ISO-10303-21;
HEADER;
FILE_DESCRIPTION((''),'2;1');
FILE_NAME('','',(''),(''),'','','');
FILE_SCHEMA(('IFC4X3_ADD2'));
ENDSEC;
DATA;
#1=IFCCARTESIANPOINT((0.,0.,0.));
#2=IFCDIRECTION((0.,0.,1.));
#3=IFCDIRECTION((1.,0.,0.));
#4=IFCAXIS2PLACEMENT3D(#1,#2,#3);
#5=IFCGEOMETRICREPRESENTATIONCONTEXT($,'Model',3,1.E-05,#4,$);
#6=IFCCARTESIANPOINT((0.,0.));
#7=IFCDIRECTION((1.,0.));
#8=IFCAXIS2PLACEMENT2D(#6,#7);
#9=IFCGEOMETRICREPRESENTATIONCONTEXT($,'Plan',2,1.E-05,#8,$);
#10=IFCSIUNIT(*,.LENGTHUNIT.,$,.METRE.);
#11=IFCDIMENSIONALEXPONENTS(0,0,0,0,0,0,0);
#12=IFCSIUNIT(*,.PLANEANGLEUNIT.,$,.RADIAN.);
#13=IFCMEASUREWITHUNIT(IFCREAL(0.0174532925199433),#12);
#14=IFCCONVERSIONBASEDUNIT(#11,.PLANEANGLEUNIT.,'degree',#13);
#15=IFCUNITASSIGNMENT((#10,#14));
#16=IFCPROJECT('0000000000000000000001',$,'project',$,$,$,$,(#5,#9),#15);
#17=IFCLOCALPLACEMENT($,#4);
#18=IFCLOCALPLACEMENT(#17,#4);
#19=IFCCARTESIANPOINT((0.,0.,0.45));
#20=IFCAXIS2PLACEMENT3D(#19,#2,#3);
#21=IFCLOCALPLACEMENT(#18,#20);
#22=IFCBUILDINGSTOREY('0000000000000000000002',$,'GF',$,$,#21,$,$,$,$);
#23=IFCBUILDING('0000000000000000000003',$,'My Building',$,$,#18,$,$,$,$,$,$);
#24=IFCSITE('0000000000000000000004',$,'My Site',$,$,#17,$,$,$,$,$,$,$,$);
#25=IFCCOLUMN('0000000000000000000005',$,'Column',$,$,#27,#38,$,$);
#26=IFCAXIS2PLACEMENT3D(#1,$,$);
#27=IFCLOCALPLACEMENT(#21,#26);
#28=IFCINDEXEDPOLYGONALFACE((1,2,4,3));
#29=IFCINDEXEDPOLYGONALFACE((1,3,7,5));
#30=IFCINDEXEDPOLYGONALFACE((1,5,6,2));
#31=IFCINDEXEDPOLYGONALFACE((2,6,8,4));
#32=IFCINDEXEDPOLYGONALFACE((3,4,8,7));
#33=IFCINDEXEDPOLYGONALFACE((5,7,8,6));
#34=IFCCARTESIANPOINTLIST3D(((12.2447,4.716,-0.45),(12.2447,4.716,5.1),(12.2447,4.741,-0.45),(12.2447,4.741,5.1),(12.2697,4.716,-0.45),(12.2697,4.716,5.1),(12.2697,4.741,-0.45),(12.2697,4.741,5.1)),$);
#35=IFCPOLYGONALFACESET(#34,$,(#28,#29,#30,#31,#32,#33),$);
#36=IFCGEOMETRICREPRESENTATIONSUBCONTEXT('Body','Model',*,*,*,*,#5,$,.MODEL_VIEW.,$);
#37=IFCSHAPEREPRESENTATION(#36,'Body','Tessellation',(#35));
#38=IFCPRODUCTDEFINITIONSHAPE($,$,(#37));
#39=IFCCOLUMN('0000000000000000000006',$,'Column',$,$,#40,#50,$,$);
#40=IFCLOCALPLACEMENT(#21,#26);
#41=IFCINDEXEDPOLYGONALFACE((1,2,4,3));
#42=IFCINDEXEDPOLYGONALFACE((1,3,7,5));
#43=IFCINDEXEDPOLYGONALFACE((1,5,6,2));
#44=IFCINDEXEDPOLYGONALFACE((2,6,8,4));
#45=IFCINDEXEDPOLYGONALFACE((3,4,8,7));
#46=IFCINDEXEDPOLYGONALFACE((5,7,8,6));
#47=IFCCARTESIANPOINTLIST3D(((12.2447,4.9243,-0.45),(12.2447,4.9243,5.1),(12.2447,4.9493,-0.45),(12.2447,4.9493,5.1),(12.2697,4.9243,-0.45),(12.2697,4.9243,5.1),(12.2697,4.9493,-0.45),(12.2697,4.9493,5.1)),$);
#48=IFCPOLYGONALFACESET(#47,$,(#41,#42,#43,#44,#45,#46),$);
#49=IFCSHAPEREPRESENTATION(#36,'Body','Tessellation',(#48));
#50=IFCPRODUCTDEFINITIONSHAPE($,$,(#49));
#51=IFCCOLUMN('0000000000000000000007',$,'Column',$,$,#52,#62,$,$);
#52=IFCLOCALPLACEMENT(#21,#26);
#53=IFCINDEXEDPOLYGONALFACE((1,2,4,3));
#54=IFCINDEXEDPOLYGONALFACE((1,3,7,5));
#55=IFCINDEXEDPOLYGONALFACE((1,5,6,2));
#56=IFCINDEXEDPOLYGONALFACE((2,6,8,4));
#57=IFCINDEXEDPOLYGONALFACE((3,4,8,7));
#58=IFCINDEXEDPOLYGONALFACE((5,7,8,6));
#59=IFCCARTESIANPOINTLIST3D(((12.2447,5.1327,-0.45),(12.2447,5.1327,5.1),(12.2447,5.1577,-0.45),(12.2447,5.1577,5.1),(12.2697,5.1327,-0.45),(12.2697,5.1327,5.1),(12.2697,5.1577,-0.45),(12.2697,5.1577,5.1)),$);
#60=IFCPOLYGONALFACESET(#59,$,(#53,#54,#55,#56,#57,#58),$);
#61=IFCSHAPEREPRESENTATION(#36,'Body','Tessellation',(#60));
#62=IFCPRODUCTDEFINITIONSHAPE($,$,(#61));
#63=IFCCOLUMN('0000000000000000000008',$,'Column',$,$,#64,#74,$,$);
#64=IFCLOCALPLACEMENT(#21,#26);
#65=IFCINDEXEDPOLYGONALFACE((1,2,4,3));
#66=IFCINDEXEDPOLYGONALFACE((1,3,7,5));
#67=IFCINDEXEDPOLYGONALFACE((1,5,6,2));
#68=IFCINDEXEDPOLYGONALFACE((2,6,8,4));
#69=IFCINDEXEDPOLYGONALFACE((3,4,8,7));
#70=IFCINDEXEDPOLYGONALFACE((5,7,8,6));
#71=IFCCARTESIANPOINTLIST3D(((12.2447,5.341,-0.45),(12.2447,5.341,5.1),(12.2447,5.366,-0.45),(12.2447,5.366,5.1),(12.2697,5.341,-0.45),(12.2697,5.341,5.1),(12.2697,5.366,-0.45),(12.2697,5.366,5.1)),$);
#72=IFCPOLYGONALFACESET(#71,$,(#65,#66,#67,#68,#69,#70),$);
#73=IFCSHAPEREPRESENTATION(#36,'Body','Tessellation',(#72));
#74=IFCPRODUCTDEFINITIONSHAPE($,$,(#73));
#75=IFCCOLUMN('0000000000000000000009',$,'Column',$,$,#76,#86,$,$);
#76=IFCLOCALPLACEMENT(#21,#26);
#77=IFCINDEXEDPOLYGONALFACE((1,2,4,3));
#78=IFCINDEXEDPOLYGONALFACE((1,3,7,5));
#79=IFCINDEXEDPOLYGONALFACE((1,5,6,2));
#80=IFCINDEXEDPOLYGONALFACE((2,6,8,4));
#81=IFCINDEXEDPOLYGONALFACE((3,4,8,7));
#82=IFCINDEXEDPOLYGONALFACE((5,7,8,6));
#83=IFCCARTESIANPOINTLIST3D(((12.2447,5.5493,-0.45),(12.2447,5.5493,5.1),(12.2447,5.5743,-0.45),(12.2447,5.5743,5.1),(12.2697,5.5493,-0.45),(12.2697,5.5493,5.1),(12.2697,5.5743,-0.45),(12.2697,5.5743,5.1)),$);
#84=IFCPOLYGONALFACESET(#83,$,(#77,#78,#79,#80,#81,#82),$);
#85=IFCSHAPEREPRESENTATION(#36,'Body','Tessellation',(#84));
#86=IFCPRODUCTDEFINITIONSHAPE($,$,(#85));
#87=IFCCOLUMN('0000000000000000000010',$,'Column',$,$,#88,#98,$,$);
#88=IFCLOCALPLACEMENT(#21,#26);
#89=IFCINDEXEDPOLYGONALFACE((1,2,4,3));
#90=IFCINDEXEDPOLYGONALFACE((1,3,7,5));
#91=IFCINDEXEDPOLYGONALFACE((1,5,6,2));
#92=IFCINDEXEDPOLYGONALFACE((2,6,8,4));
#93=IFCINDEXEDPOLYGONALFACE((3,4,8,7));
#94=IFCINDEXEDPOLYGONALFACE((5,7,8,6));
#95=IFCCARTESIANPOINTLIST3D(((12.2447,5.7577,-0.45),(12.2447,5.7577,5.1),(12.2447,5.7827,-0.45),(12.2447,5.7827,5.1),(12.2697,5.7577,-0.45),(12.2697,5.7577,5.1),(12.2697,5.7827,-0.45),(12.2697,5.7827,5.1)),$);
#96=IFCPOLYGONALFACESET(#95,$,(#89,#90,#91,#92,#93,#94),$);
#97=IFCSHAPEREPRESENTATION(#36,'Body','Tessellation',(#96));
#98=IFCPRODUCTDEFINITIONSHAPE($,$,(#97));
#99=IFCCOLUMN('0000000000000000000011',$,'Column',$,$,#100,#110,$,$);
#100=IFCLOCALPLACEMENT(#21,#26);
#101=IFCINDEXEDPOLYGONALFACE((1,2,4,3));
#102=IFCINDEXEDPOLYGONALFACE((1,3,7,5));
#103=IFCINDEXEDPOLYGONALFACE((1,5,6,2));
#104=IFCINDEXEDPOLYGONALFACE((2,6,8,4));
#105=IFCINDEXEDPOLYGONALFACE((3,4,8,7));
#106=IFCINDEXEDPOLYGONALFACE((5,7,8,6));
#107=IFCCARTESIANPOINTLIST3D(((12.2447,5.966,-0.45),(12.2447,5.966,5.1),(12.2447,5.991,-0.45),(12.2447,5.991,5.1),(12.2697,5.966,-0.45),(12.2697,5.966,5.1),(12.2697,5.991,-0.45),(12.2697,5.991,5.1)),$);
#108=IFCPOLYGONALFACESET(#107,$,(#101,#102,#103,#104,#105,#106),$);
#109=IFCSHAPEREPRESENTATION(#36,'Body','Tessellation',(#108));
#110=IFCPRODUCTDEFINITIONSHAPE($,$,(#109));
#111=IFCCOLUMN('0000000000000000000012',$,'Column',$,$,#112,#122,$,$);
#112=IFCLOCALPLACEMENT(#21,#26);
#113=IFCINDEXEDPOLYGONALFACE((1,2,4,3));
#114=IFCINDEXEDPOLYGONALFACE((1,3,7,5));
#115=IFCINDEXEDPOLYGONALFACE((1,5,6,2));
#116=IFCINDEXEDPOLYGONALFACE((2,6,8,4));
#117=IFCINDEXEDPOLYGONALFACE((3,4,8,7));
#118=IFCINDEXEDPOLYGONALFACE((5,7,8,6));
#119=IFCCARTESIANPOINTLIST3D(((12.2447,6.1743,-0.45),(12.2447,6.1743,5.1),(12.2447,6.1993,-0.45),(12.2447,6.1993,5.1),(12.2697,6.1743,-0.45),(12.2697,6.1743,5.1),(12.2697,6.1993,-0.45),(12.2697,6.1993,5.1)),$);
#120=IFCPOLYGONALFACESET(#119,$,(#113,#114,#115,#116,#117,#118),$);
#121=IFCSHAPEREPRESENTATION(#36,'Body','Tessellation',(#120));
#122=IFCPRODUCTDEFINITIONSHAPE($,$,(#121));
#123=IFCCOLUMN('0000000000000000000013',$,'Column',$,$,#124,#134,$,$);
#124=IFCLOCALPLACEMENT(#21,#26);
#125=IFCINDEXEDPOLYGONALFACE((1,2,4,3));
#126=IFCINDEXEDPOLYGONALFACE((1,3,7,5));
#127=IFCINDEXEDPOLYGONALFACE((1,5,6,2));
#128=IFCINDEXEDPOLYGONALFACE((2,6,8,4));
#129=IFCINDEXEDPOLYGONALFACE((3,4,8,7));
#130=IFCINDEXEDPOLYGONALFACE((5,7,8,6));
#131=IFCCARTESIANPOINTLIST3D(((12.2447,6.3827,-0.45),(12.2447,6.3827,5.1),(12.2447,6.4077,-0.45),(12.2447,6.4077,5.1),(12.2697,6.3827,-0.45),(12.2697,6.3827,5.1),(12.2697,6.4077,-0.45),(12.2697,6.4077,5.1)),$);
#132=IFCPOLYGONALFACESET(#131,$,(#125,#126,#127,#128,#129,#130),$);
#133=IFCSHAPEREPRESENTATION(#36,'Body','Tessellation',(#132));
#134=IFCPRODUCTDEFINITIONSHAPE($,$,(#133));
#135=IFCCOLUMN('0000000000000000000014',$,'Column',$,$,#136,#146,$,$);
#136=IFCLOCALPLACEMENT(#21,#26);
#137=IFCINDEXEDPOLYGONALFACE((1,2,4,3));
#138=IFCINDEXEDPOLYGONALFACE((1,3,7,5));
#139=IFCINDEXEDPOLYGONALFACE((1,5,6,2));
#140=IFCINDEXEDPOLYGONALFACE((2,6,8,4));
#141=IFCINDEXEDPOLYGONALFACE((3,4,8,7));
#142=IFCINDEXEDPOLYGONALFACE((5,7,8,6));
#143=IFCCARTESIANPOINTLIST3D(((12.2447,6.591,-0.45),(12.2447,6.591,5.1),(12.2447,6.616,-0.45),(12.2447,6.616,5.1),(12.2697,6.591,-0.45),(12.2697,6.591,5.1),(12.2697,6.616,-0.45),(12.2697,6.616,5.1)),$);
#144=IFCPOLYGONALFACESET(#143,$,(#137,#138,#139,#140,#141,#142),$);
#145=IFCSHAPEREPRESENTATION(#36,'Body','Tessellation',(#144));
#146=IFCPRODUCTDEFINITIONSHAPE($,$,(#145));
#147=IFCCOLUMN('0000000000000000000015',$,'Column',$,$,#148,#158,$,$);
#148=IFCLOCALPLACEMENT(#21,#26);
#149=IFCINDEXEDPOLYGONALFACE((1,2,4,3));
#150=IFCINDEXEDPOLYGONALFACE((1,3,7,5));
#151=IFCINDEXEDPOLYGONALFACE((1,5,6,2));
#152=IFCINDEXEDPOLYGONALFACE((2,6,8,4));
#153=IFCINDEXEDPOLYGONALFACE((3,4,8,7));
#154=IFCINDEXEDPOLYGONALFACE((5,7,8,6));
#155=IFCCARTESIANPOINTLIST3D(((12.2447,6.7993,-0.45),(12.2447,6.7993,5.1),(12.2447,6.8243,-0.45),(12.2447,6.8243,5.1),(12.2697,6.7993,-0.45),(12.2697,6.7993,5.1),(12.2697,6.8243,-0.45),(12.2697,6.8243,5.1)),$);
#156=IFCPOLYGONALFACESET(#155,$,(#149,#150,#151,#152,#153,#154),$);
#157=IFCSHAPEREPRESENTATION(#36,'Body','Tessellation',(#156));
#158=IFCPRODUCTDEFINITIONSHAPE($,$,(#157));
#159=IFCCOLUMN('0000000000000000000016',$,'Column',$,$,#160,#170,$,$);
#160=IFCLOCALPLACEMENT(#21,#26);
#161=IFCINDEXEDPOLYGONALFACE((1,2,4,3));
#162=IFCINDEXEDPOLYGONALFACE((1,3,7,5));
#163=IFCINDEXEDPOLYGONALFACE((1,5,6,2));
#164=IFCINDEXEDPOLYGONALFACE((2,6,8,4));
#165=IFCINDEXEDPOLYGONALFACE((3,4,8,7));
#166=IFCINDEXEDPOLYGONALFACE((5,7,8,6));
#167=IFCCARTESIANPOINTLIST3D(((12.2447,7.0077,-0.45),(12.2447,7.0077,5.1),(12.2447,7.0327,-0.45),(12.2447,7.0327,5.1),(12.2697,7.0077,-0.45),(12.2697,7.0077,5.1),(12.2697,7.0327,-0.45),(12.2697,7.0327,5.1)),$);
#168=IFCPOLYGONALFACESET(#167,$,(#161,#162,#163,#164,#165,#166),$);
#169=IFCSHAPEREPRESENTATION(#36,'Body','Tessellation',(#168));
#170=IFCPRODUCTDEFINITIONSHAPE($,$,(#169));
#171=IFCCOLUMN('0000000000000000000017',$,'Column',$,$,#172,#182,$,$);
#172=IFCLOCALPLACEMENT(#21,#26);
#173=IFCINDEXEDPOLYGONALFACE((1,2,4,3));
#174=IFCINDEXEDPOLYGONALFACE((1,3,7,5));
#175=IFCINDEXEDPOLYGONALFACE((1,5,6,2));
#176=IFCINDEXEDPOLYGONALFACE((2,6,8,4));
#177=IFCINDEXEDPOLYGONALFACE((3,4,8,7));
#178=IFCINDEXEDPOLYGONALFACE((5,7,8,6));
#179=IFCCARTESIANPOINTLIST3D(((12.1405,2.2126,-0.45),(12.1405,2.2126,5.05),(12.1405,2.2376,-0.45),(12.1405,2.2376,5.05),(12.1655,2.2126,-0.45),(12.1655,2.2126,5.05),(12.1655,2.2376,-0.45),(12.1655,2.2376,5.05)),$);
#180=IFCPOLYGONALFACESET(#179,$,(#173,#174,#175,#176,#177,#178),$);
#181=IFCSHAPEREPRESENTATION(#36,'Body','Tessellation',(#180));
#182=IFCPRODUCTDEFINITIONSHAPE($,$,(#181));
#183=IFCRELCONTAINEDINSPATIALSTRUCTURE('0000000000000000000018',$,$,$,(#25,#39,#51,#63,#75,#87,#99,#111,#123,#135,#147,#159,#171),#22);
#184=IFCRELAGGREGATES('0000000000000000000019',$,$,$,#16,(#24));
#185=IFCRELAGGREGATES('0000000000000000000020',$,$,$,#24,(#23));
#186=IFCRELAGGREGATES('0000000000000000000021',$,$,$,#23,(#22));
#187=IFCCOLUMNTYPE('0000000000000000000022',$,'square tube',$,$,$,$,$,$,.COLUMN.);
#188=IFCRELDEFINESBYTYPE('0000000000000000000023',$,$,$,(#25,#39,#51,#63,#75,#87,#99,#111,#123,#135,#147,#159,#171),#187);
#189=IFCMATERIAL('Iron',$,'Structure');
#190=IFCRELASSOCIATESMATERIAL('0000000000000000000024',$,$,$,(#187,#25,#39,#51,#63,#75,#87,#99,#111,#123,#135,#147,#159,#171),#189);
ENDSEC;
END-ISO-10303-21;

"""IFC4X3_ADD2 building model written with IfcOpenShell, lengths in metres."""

from ifc_helpers import new_model, entity, si_unit, converted_unit, frame, origin_with_axes, origin_2d_with_axis, place, context, subcontext, project, spatial, indexed_curve, outline, extrude, material, material_profile, profile_set, profile_usage, type_object, element, save


model = new_model("IFC4X3_ADD2")

# Units and contexts
model_context = context("Model", 3, precision=1e-05, world=origin_with_axes())
plan_context = context("Plan", 2, precision=1e-05, world=origin_2d_with_axis())
body_context = subcontext(model_context, "Body", "Model", "MODEL_VIEW")
ifc_project = project(units=[si_unit("LENGTHUNIT", "METRE"), converted_unit("PLANEANGLEUNIT", "degree", entity("IfcReal", 0.0174532925199433), si_unit("PLANEANGLEUNIT", "RADIAN"), dimensions=[0, 0, 0, 0, 0, 0, 0])], contexts=[model_context, plan_context])

# Site, building, storey
site_placement = place(None, origin_with_axes())
site = spatial("IfcSite", under=ifc_project, at=site_placement, Name="My Site")
building_placement = place(site_placement, origin_with_axes())
building = spatial("IfcBuilding", under=site, at=building_placement, Name="My Building")
storey_placement = place(building_placement, frame((0.0, 0.0, 0.45), z_axis=(0.0, 0.0, 1.0), x_axis=(1.0, 0.0, 0.0)))
storey = spatial("IfcBuildingStorey", under=building, at=storey_placement, Name="GF")

# Columns
ifc_material_1 = material(Name="Iron", Category="Structure")
ifc_material_profile = material_profile(ifc_material_1, outline(indexed_curve([(-0.0125, -0.0125), (0.0125, -0.0125), (0.0125, 0.0125), (-0.0125, 0.0125), (-0.0125, -0.0125)])))
ifc_profile_set = profile_set([ifc_material_profile])
column_type = type_object("IfcColumnType", Name="square tube", PredefinedType="COLUMN", material=ifc_profile_set)
ifc_profile_usage_1 = profile_usage(ifc_profile_set, cardinal=5)
column_1_placement = place(storey_placement, frame((12.2572, 4.7285, -0.45), z_axis=(0.0, 0.0, 1.0), x_axis=(0.0, 1.0, 0.0)))
element("IfcColumn", 1, at=column_1_placement, inside=storey, type_object=column_type, material=ifc_profile_usage_1, Name="Column", context=body_context, shape_type="SweptSolid", body=[
    extrude(outline(indexed_curve([(-0.0125, -0.0125), (0.0125, -0.0125), (0.0125, 0.0125), (-0.0125, 0.0125), (-0.0125, -0.0125)])), origin_with_axes(), (0.0, 0.0, 1.0), 5.55),
])
ifc_profile_usage_2 = profile_usage(ifc_profile_set, cardinal=5)
column_2_placement = place(storey_placement, frame((12.2572, 4.9368, -0.45), z_axis=(0.0, 0.0, 1.0), x_axis=(0.0, 1.0, 0.0)))
element("IfcColumn", 2, at=column_2_placement, inside=storey, type_object=column_type, material=ifc_profile_usage_2, Name="Column", context=body_context, shape_type="SweptSolid", body=[
    extrude(outline(indexed_curve([(-0.0125, -0.0125), (0.0125, -0.0125), (0.0125, 0.0125), (-0.0125, 0.0125), (-0.0125, -0.0125)])), origin_with_axes(), (0.0, 0.0, 1.0), 5.55),
])
ifc_profile_usage_3 = profile_usage(ifc_profile_set, cardinal=5)
column_3_placement = place(storey_placement, frame((12.2572, 5.1452, -0.45), z_axis=(0.0, 0.0, 1.0), x_axis=(0.0, 1.0, 0.0)))
element("IfcColumn", 3, at=column_3_placement, inside=storey, type_object=column_type, material=ifc_profile_usage_3, Name="Column", context=body_context, shape_type="SweptSolid", body=[
    extrude(outline(indexed_curve([(-0.0125, -0.0125), (0.0125, -0.0125), (0.0125, 0.0125), (-0.0125, 0.0125), (-0.0125, -0.0125)])), origin_with_axes(), (0.0, 0.0, 1.0), 5.55),
])
ifc_profile_usage_4 = profile_usage(ifc_profile_set, cardinal=5)
column_4_placement = place(storey_placement, frame((12.2572, 5.3535, -0.45), z_axis=(0.0, 0.0, 1.0), x_axis=(0.0, 1.0, 0.0)))
element("IfcColumn", 4, at=column_4_placement, inside=storey, type_object=column_type, material=ifc_profile_usage_4, Name="Column", context=body_context, shape_type="SweptSolid", body=[
    extrude(outline(indexed_curve([(-0.0125, -0.0125), (0.0125, -0.0125), (0.0125, 0.0125), (-0.0125, 0.0125), (-0.0125, -0.0125)])), origin_with_axes(), (0.0, 0.0, 1.0), 5.55),
])
ifc_profile_usage_5 = profile_usage(ifc_profile_set, cardinal=5)
column_5_placement = place(storey_placement, frame((12.2572, 5.5618, -0.45), z_axis=(0.0, 0.0, 1.0), x_axis=(0.0, 1.0, 0.0)))
element("IfcColumn", 5, at=column_5_placement, inside=storey, type_object=column_type, material=ifc_profile_usage_5, Name="Column", context=body_context, shape_type="SweptSolid", body=[
    extrude(outline(indexed_curve([(-0.0125, -0.0125), (0.0125, -0.0125), (0.0125, 0.0125), (-0.0125, 0.0125), (-0.0125, -0.0125)])), origin_with_axes(), (0.0, 0.0, 1.0), 5.55),
])
ifc_profile_usage_6 = profile_usage(ifc_profile_set, cardinal=5)
column_6_placement = place(storey_placement, frame((12.2572, 5.7702, -0.45), z_axis=(0.0, 0.0, 1.0), x_axis=(0.0, 1.0, 0.0)))
element("IfcColumn", 6, at=column_6_placement, inside=storey, type_object=column_type, material=ifc_profile_usage_6, Name="Column", context=body_context, shape_type="SweptSolid", body=[
    extrude(outline(indexed_curve([(-0.0125, -0.0125), (0.0125, -0.0125), (0.0125, 0.0125), (-0.0125, 0.0125), (-0.0125, -0.0125)])), origin_with_axes(), (0.0, 0.0, 1.0), 5.55),
])
ifc_profile_usage_7 = profile_usage(ifc_profile_set, cardinal=5)
column_7_placement = place(storey_placement, frame((12.2572, 5.9785, -0.45), z_axis=(0.0, 0.0, 1.0), x_axis=(0.0, 1.0, 0.0)))
element("IfcColumn", 7, at=column_7_placement, inside=storey, type_object=column_type, material=ifc_profile_usage_7, Name="Column", context=body_context, shape_type="SweptSolid", body=[
    extrude(outline(indexed_curve([(-0.0125, -0.0125), (0.0125, -0.0125), (0.0125, 0.0125), (-0.0125, 0.0125), (-0.0125, -0.0125)])), origin_with_axes(), (0.0, 0.0, 1.0), 5.55),
])
ifc_profile_usage_8 = profile_usage(ifc_profile_set, cardinal=5)
column_8_placement = place(storey_placement, frame((12.2572, 6.1868, -0.45), z_axis=(0.0, 0.0, 1.0), x_axis=(0.0, 1.0, 0.0)))
element("IfcColumn", 8, at=column_8_placement, inside=storey, type_object=column_type, material=ifc_profile_usage_8, Name="Column", context=body_context, shape_type="SweptSolid", body=[
    extrude(outline(indexed_curve([(-0.0125, -0.0125), (0.0125, -0.0125), (0.0125, 0.0125), (-0.0125, 0.0125), (-0.0125, -0.0125)])), origin_with_axes(), (0.0, 0.0, 1.0), 5.55),
])
ifc_profile_usage_9 = profile_usage(ifc_profile_set, cardinal=5)
column_9_placement = place(storey_placement, frame((12.2572, 6.3952, -0.45), z_axis=(0.0, 0.0, 1.0), x_axis=(0.0, 1.0, 0.0)))
element("IfcColumn", 9, at=column_9_placement, inside=storey, type_object=column_type, material=ifc_profile_usage_9, Name="Column", context=body_context, shape_type="SweptSolid", body=[
    extrude(outline(indexed_curve([(-0.0125, -0.0125), (0.0125, -0.0125), (0.0125, 0.0125), (-0.0125, 0.0125), (-0.0125, -0.0125)])), origin_with_axes(), (0.0, 0.0, 1.0), 5.55),
])
ifc_profile_usage_10 = profile_usage(ifc_profile_set, cardinal=5)
column_10_placement = place(storey_placement, frame((12.2572, 6.6035, -0.45), z_axis=(0.0, 0.0, 1.0), x_axis=(0.0, 1.0, 0.0)))
element("IfcColumn", 10, at=column_10_placement, inside=storey, type_object=column_type, material=ifc_profile_usage_10, Name="Column", context=body_context, shape_type="SweptSolid", body=[
    extrude(outline(indexed_curve([(-0.0125, -0.0125), (0.0125, -0.0125), (0.0125, 0.0125), (-0.0125, 0.0125), (-0.0125, -0.0125)])), origin_with_axes(), (0.0, 0.0, 1.0), 5.55),
])
ifc_profile_usage_11 = profile_usage(ifc_profile_set, cardinal=5)
column_11_placement = place(storey_placement, frame((12.2572, 6.8118, -0.45), z_axis=(0.0, 0.0, 1.0), x_axis=(0.0, 1.0, 0.0)))
element("IfcColumn", 11, at=column_11_placement, inside=storey, type_object=column_type, material=ifc_profile_usage_11, Name="Column", context=body_context, shape_type="SweptSolid", body=[
    extrude(outline(indexed_curve([(-0.0125, -0.0125), (0.0125, -0.0125), (0.0125, 0.0125), (-0.0125, 0.0125), (-0.0125, -0.0125)])), origin_with_axes(), (0.0, 0.0, 1.0), 5.55),
])
ifc_profile_usage_12 = profile_usage(ifc_profile_set, cardinal=5)
column_12_placement = place(storey_placement, frame((12.2572, 7.0202, -0.45), z_axis=(0.0, 0.0, 1.0), x_axis=(0.0, 1.0, 0.0)))
element("IfcColumn", 12, at=column_12_placement, inside=storey, type_object=column_type, material=ifc_profile_usage_12, Name="Column", context=body_context, shape_type="SweptSolid", body=[
    extrude(outline(indexed_curve([(-0.0125, -0.0125), (0.0125, -0.0125), (0.0125, 0.0125), (-0.0125, 0.0125), (-0.0125, -0.0125)])), origin_with_axes(), (0.0, 0.0, 1.0), 5.55),
])
ifc_profile_usage_13 = profile_usage(ifc_profile_set, cardinal=5)
column_13_placement = place(storey_placement, frame((12.153, 2.2251, -0.45), z_axis=(0.0, 0.0, 1.0), x_axis=(1.0, 0.0, 0.0)))
element("IfcColumn", 13, at=column_13_placement, inside=storey, type_object=column_type, material=ifc_profile_usage_13, Name="Column", context=body_context, shape_type="SweptSolid", body=[
    extrude(outline(indexed_curve([(-0.0125, -0.0125), (0.0125, -0.0125), (0.0125, 0.0125), (-0.0125, 0.0125), (-0.0125, -0.0125)])), origin_with_axes(), (0.0, 0.0, 1.0), 5.5),
])

save(model, "model.ifc")
